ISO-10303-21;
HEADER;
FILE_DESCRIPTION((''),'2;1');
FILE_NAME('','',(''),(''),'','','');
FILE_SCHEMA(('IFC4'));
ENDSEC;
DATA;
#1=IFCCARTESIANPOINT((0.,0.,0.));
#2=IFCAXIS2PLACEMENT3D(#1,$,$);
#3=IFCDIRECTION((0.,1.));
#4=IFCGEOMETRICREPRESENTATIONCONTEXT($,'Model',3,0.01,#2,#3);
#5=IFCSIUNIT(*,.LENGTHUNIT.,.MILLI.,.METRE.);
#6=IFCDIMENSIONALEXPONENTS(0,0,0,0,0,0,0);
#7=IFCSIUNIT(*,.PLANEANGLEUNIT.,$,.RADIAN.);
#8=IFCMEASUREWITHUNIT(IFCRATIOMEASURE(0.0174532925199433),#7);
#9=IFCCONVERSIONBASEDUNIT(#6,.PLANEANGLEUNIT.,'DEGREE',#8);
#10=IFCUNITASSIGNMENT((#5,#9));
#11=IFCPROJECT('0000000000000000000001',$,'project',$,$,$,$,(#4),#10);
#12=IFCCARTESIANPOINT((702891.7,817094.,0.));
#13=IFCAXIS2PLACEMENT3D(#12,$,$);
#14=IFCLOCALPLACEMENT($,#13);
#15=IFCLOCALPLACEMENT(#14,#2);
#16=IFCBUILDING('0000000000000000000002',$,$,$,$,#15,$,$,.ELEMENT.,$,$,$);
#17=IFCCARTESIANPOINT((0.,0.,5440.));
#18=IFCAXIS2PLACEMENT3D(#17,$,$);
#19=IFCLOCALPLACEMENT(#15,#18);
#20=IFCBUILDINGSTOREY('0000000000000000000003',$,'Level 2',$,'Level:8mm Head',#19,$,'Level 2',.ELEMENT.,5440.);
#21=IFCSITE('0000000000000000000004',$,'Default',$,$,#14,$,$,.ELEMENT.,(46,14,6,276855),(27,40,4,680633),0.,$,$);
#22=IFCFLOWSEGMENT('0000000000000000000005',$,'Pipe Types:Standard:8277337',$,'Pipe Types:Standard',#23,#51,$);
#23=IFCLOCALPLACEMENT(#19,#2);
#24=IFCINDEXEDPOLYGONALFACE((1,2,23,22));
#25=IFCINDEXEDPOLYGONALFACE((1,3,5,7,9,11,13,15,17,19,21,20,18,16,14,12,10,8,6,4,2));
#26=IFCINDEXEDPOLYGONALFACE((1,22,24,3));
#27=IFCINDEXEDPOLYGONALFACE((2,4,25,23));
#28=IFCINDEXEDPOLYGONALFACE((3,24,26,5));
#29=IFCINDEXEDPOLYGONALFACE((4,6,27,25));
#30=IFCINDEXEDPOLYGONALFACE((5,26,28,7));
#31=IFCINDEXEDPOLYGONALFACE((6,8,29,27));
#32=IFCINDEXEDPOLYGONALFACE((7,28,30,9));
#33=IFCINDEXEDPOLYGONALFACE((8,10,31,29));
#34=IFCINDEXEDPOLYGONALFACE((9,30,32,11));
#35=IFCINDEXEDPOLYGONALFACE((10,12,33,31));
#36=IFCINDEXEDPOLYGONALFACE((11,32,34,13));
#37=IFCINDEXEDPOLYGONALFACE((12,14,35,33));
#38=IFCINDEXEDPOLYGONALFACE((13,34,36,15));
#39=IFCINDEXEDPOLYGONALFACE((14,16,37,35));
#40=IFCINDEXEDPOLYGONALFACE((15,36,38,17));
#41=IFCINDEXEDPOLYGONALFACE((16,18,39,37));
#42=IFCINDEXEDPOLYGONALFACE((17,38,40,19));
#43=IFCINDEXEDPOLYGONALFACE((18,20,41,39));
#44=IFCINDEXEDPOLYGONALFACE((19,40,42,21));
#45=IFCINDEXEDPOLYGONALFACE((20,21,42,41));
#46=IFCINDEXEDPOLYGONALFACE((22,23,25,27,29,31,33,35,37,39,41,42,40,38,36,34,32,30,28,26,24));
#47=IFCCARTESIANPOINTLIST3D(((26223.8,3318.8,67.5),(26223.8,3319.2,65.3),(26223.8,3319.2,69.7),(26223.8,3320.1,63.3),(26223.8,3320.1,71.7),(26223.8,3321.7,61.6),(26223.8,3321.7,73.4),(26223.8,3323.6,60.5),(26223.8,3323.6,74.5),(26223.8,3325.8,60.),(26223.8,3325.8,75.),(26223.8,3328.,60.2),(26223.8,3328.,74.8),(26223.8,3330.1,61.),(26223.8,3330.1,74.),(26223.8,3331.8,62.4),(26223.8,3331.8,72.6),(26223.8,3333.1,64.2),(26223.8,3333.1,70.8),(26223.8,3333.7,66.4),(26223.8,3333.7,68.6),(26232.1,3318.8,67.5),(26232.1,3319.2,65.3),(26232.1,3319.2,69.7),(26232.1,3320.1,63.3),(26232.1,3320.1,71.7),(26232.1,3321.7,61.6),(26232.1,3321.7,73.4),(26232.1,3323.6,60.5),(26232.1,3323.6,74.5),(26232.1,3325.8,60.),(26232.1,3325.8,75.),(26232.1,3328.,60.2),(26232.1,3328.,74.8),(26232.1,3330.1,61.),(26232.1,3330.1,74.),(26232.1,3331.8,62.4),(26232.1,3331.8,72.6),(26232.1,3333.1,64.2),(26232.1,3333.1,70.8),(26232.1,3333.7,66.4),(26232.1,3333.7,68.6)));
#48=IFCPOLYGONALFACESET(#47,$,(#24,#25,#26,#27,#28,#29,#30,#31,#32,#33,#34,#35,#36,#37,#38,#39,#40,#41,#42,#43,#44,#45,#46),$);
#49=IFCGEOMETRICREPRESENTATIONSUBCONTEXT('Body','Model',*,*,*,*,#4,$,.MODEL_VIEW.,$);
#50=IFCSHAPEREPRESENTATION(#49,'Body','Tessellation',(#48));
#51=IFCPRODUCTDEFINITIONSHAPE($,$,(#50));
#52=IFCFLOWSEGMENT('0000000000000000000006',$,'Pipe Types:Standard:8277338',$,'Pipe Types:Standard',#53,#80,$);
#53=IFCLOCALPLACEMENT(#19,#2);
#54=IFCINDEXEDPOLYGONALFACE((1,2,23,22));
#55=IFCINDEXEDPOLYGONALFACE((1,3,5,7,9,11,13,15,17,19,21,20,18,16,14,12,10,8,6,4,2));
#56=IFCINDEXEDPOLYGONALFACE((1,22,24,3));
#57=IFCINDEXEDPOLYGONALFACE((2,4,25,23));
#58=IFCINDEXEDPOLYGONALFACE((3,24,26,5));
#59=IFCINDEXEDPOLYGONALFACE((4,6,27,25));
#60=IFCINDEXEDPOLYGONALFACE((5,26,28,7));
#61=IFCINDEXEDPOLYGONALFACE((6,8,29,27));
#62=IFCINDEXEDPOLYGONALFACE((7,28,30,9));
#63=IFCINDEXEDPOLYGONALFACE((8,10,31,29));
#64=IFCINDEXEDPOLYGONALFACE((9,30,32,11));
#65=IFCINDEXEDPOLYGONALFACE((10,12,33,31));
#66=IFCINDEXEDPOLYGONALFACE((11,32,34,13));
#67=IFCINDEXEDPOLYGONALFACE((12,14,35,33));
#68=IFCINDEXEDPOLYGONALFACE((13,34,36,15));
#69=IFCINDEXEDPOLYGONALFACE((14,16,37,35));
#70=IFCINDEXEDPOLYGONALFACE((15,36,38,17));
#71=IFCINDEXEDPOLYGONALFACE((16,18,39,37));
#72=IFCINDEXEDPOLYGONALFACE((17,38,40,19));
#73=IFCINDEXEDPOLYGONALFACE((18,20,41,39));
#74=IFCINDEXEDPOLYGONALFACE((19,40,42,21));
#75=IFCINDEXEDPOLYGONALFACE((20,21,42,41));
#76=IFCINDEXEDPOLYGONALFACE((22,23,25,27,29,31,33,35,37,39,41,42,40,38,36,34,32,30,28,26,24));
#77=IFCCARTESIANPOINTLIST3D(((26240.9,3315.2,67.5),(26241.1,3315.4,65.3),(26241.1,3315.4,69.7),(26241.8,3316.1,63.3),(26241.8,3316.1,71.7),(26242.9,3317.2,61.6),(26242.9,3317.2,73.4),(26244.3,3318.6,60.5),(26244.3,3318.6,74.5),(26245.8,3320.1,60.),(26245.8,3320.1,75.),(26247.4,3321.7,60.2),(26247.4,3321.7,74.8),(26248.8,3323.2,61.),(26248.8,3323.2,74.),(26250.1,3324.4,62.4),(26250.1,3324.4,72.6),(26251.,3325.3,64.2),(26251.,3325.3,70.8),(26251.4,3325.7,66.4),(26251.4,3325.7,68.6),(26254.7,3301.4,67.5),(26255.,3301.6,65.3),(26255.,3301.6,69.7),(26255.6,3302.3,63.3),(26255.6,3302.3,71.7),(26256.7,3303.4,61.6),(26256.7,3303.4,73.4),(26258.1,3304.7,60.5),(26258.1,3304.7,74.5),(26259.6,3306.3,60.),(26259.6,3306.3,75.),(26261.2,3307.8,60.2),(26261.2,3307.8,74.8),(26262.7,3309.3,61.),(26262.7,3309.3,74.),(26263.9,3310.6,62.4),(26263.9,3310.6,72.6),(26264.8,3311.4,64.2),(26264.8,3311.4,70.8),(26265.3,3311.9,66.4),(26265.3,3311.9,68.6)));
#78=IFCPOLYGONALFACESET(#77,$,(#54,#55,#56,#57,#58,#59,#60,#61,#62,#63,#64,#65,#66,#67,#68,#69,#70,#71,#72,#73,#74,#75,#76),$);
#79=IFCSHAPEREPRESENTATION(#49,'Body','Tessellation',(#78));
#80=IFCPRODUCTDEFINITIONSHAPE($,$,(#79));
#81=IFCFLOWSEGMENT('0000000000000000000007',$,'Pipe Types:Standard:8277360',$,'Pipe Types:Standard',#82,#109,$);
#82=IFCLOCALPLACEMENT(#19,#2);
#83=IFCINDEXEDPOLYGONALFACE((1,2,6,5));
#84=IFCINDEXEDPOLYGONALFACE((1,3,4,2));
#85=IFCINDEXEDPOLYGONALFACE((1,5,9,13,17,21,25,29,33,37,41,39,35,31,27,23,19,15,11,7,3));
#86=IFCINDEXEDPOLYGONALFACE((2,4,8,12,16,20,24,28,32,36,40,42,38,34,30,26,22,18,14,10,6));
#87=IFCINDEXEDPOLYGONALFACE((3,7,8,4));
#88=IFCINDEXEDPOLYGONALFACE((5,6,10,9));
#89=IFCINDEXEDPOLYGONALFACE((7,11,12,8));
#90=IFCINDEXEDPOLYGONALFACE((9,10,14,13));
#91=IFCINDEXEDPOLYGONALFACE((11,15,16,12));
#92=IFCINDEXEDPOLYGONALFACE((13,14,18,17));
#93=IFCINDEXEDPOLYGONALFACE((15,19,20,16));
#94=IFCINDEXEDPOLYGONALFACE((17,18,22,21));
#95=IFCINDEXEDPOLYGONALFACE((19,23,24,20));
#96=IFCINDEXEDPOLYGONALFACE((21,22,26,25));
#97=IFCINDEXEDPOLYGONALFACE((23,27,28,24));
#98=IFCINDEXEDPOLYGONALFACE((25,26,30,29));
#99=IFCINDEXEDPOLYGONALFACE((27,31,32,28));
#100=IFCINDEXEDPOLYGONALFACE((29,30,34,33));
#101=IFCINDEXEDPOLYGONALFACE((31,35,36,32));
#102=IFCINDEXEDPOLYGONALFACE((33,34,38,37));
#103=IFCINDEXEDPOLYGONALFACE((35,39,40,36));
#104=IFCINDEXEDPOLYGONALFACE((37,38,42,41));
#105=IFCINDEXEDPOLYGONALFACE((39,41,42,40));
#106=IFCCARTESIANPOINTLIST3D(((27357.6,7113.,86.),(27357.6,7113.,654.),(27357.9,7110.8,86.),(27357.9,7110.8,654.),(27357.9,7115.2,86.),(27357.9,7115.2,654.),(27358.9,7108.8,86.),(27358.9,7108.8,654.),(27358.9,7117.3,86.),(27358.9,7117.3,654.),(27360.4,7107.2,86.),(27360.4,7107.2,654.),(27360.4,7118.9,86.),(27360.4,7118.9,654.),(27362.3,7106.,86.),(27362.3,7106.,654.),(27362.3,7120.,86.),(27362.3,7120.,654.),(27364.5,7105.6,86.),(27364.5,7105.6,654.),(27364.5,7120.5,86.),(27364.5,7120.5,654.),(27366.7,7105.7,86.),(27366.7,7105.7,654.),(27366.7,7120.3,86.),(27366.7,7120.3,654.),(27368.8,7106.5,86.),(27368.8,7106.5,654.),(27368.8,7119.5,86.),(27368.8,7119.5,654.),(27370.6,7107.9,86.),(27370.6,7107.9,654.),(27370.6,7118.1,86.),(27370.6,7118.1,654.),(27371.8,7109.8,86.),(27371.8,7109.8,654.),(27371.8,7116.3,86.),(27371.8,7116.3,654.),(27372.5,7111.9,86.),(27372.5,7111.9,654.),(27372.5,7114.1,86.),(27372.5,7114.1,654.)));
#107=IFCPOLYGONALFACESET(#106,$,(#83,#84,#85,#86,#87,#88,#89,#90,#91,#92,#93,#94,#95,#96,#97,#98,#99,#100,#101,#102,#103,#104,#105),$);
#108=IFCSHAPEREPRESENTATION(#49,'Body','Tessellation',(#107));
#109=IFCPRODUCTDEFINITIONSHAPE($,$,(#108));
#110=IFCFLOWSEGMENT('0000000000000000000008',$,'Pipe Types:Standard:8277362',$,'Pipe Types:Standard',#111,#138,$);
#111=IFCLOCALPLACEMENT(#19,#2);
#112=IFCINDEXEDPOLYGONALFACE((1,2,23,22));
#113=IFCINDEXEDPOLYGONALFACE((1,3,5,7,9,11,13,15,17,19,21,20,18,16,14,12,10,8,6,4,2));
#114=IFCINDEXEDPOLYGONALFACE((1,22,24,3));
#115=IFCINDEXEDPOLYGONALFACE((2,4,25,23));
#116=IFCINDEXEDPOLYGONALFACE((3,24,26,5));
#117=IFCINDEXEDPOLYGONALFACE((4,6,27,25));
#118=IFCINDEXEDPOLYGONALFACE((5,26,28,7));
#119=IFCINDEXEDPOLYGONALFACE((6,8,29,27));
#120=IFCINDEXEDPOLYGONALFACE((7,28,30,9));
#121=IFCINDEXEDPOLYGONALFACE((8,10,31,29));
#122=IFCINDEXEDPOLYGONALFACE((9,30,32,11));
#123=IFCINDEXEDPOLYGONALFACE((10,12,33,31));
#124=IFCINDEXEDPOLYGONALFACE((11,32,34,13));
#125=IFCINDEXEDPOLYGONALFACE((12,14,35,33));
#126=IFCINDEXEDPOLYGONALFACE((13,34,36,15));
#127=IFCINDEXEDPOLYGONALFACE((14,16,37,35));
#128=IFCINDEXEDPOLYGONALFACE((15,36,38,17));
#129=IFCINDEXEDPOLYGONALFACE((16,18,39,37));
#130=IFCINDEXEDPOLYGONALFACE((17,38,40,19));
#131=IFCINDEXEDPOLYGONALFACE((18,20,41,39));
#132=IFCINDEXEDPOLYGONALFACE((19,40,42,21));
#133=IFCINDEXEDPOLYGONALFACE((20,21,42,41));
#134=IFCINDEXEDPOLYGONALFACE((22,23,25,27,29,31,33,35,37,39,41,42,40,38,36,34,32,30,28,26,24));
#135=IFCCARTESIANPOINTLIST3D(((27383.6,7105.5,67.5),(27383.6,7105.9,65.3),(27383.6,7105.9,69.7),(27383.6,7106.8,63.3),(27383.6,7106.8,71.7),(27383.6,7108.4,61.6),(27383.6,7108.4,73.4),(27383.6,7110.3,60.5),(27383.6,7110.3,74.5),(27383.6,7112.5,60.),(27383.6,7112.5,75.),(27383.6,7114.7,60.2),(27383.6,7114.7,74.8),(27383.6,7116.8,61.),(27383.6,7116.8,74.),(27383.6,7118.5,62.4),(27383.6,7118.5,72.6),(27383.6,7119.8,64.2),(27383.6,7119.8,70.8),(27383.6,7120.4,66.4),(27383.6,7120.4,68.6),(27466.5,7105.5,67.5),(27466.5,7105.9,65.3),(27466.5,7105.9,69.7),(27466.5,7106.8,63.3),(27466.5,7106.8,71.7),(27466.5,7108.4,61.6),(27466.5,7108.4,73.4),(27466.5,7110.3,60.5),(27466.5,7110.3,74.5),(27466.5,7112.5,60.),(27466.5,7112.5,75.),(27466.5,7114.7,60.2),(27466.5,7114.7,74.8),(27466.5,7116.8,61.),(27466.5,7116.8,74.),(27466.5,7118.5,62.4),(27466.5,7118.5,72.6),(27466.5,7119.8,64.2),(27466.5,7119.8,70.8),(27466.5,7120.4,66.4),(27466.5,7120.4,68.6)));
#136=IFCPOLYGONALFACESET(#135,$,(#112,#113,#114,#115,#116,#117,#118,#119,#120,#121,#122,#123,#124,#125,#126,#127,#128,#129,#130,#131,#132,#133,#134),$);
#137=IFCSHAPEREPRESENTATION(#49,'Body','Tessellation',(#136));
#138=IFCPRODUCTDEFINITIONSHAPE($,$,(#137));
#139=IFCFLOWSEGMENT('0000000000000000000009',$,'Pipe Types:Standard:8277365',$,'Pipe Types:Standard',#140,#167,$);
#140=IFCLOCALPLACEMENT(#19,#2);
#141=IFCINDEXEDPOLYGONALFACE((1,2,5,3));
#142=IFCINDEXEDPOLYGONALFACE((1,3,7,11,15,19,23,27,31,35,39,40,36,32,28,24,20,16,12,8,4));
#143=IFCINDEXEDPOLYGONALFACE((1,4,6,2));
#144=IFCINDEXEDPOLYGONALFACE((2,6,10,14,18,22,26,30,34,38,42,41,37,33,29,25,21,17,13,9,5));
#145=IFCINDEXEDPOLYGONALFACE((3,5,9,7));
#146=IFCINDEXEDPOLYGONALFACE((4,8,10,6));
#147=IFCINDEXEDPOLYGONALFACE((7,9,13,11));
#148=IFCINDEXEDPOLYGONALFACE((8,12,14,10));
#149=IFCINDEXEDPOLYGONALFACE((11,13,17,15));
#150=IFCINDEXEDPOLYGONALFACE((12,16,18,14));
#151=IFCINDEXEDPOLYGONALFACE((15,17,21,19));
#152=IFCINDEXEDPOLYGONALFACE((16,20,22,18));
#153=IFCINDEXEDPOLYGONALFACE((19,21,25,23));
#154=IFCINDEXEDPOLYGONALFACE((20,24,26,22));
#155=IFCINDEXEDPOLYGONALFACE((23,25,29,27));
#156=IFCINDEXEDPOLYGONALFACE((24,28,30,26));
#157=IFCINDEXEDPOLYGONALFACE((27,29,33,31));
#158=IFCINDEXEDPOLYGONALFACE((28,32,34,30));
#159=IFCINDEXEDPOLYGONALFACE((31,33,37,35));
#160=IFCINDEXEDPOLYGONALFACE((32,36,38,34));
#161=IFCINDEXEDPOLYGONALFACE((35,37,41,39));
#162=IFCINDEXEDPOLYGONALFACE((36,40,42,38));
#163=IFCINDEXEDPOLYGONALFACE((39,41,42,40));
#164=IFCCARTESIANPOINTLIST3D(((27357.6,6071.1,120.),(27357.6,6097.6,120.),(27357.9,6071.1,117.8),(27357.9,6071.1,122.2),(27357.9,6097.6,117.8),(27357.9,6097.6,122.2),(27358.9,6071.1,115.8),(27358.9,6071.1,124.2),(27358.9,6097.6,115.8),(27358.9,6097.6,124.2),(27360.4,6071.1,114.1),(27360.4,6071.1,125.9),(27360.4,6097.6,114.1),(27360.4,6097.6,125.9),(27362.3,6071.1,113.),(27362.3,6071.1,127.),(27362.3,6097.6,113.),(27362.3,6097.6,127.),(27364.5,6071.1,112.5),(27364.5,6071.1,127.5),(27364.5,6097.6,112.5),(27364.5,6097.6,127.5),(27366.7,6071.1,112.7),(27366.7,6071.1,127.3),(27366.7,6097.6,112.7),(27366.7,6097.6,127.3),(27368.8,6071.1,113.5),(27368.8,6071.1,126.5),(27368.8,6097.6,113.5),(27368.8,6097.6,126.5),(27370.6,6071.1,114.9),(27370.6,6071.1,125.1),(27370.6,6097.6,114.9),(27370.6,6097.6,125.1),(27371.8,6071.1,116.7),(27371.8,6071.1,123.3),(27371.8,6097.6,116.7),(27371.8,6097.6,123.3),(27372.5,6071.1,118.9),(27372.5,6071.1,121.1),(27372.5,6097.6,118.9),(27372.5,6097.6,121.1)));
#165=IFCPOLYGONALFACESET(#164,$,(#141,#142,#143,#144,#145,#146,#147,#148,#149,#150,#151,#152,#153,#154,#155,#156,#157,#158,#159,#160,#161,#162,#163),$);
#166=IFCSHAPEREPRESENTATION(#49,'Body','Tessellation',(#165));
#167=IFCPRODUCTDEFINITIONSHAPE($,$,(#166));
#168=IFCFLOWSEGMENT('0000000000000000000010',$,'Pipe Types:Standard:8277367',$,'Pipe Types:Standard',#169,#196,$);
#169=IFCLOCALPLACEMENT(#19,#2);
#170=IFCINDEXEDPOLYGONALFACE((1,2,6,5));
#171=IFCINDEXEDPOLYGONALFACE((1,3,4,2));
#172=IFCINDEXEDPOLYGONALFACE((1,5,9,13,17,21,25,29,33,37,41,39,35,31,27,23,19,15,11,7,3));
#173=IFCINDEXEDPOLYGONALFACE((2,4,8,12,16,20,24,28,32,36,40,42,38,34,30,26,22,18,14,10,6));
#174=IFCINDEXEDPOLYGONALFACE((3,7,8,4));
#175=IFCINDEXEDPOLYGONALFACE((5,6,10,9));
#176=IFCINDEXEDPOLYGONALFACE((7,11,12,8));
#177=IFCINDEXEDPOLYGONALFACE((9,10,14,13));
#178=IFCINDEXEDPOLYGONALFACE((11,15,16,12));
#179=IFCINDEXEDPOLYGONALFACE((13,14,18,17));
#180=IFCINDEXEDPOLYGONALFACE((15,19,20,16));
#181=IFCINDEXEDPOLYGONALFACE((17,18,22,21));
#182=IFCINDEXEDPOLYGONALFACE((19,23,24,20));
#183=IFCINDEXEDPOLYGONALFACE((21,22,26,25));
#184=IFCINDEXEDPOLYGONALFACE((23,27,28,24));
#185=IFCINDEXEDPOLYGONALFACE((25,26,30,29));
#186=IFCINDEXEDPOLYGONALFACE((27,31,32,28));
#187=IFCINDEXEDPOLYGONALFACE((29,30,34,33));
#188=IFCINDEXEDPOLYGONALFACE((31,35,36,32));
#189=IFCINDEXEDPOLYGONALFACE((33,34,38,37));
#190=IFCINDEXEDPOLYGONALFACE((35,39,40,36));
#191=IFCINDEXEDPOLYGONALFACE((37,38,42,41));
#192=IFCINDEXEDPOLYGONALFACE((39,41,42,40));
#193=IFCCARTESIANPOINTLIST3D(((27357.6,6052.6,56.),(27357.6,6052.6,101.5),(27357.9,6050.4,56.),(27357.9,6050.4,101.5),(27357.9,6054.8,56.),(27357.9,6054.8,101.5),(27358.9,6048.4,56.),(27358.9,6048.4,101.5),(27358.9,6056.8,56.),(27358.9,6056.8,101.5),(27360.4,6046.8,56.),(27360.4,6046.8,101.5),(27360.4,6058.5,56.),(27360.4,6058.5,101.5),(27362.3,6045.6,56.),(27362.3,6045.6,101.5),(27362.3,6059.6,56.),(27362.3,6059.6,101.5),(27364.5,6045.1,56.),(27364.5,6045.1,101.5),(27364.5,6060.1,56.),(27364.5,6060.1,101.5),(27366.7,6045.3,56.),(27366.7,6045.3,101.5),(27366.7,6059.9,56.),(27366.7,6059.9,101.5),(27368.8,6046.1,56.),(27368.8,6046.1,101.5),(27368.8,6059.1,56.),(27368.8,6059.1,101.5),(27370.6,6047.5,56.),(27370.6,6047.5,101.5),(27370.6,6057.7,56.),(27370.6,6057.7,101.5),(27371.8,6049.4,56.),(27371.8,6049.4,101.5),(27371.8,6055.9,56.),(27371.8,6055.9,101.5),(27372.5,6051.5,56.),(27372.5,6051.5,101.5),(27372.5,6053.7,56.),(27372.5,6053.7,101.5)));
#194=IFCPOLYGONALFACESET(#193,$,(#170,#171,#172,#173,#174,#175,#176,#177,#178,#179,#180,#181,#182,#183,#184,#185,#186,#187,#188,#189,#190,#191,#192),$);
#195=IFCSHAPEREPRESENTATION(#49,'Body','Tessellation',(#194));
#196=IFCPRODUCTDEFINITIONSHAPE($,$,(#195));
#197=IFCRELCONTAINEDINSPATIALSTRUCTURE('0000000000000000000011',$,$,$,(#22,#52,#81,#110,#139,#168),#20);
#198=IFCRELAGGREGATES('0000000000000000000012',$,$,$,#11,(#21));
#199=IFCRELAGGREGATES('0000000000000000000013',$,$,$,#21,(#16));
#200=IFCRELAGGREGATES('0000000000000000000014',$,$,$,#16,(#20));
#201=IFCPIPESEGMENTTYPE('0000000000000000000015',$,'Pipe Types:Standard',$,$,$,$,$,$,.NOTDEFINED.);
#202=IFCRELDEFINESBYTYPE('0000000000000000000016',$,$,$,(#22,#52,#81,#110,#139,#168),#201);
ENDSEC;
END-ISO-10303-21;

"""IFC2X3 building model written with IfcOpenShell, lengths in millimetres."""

from ifc_helpers import new_model, entity, si_unit, converted_unit, direction, frame, origin, origin_2d_with_axis, place, context, subcontext, project, spatial, circle, extrude, type_object, element, save


model = new_model("IFC2X3")

# Units and contexts
model_context = context("Model", 3, precision=0.01, world=origin(), true_north=direction((0.0, 1.0)))
body_context = subcontext(model_context, "Body", "Model", "MODEL_VIEW")
ifc_project = project(units=[si_unit("LENGTHUNIT", "METRE", prefix="MILLI"), converted_unit("PLANEANGLEUNIT", "DEGREE", entity("IfcRatioMeasure", 0.0174532925199433), si_unit("PLANEANGLEUNIT", "RADIAN"), dimensions=[0, 0, 0, 0, 0, 0, 0])], contexts=[model_context])

# Site, building, storey
site_placement = place(None, frame((702891.7, 817094.0, 0.0)))
site = spatial("IfcSite", under=ifc_project, at=site_placement, Name="Default", CompositionType="ELEMENT", RefLatitude=(46, 14, 6, 276855), RefLongitude=(27, 40, 4, 680633), RefElevation=0.0)
building_placement = place(site_placement, origin())
building = spatial("IfcBuilding", under=site, at=building_placement, CompositionType="ELEMENT")
storey_placement = place(building_placement, frame((0.0, 0.0, 5440.0)))
storey = spatial("IfcBuildingStorey", under=building, at=storey_placement, Name="Level 2", ObjectType="Level:8mm Head", LongName="Level 2", CompositionType="ELEMENT", Elevation=5440.0)

# Flow segments
pipe_segment_type = type_object("IfcPipeSegmentType", Name="Pipe Types:Standard", PredefinedType="NOTDEFINED")
flow_segment_1_placement = place(storey_placement, origin())
element("IfcFlowSegment", 1, at=flow_segment_1_placement, inside=storey, type_object=pipe_segment_type, Name="Pipe Types:Standard:8277337", ObjectType="Pipe Types:Standard", context=body_context, shape_type="SweptSolid", body=[
    extrude(circle(Radius=7.5, at=origin_2d_with_axis()), frame((26223.8, 3326.3, 67.5), z_axis=(1.0, 0.0, 0.0), x_axis=(0.0, -1.0, 0.0)), (0.0, 0.0, 1.0), 8.3),
])
flow_segment_2_placement = place(storey_placement, origin())
element("IfcFlowSegment", 2, at=flow_segment_2_placement, inside=storey, type_object=pipe_segment_type, Name="Pipe Types:Standard:8277338", ObjectType="Pipe Types:Standard", context=body_context, shape_type="SweptSolid", body=[
    extrude(circle(Radius=7.5, at=origin_2d_with_axis()), frame((26246.2, 3320.5, 67.5), z_axis=(0.707107, -0.707107, 0.0), x_axis=(-0.707107, -0.707107, 0.0)), (0.0, 0.0, 1.0), 19.6),
])
flow_segment_3_placement = place(storey_placement, origin())
element("IfcFlowSegment", 3, at=flow_segment_3_placement, inside=storey, type_object=pipe_segment_type, Name="Pipe Types:Standard:8277360", ObjectType="Pipe Types:Standard", context=body_context, shape_type="SweptSolid", body=[
    extrude(circle(Radius=7.5, at=origin_2d_with_axis()), frame((27365.1, 7113.0, 86.0), z_axis=(0.0, 0.0, 1.0), x_axis=(-1.0, 0.0, 0.0)), (0.0, 0.0, 1.0), 568.0),
])
flow_segment_4_placement = place(storey_placement, origin())
element("IfcFlowSegment", 4, at=flow_segment_4_placement, inside=storey, type_object=pipe_segment_type, Name="Pipe Types:Standard:8277362", ObjectType="Pipe Types:Standard", context=body_context, shape_type="SweptSolid", body=[
    extrude(circle(Radius=7.5, at=origin_2d_with_axis()), frame((27383.6, 7113.0, 67.5), z_axis=(1.0, 0.0, 0.0), x_axis=(0.0, -1.0, 0.0)), (0.0, 0.0, 1.0), 82.9),
])
flow_segment_5_placement = place(storey_placement, origin())
element("IfcFlowSegment", 5, at=flow_segment_5_placement, inside=storey, type_object=pipe_segment_type, Name="Pipe Types:Standard:8277365", ObjectType="Pipe Types:Standard", context=body_context, shape_type="SweptSolid", body=[
    extrude(circle(Radius=7.5, at=origin_2d_with_axis()), frame((27365.1, 6071.1, 120.0), z_axis=(0.0, 1.0, 0.0), x_axis=(-1.0, 0.0, 0.0)), (0.0, 0.0, 1.0), 26.5),
])
flow_segment_6_placement = place(storey_placement, origin())
element("IfcFlowSegment", 6, at=flow_segment_6_placement, inside=storey, type_object=pipe_segment_type, Name="Pipe Types:Standard:8277367", ObjectType="Pipe Types:Standard", context=body_context, shape_type="SweptSolid", body=[
    extrude(circle(Radius=7.5, at=origin_2d_with_axis()), frame((27365.1, 6052.6, 56.0), z_axis=(0.0, 0.0, 1.0), x_axis=(-1.0, 0.0, 0.0)), (0.0, 0.0, 1.0), 45.5),
])

save(model, "model.ifc")
